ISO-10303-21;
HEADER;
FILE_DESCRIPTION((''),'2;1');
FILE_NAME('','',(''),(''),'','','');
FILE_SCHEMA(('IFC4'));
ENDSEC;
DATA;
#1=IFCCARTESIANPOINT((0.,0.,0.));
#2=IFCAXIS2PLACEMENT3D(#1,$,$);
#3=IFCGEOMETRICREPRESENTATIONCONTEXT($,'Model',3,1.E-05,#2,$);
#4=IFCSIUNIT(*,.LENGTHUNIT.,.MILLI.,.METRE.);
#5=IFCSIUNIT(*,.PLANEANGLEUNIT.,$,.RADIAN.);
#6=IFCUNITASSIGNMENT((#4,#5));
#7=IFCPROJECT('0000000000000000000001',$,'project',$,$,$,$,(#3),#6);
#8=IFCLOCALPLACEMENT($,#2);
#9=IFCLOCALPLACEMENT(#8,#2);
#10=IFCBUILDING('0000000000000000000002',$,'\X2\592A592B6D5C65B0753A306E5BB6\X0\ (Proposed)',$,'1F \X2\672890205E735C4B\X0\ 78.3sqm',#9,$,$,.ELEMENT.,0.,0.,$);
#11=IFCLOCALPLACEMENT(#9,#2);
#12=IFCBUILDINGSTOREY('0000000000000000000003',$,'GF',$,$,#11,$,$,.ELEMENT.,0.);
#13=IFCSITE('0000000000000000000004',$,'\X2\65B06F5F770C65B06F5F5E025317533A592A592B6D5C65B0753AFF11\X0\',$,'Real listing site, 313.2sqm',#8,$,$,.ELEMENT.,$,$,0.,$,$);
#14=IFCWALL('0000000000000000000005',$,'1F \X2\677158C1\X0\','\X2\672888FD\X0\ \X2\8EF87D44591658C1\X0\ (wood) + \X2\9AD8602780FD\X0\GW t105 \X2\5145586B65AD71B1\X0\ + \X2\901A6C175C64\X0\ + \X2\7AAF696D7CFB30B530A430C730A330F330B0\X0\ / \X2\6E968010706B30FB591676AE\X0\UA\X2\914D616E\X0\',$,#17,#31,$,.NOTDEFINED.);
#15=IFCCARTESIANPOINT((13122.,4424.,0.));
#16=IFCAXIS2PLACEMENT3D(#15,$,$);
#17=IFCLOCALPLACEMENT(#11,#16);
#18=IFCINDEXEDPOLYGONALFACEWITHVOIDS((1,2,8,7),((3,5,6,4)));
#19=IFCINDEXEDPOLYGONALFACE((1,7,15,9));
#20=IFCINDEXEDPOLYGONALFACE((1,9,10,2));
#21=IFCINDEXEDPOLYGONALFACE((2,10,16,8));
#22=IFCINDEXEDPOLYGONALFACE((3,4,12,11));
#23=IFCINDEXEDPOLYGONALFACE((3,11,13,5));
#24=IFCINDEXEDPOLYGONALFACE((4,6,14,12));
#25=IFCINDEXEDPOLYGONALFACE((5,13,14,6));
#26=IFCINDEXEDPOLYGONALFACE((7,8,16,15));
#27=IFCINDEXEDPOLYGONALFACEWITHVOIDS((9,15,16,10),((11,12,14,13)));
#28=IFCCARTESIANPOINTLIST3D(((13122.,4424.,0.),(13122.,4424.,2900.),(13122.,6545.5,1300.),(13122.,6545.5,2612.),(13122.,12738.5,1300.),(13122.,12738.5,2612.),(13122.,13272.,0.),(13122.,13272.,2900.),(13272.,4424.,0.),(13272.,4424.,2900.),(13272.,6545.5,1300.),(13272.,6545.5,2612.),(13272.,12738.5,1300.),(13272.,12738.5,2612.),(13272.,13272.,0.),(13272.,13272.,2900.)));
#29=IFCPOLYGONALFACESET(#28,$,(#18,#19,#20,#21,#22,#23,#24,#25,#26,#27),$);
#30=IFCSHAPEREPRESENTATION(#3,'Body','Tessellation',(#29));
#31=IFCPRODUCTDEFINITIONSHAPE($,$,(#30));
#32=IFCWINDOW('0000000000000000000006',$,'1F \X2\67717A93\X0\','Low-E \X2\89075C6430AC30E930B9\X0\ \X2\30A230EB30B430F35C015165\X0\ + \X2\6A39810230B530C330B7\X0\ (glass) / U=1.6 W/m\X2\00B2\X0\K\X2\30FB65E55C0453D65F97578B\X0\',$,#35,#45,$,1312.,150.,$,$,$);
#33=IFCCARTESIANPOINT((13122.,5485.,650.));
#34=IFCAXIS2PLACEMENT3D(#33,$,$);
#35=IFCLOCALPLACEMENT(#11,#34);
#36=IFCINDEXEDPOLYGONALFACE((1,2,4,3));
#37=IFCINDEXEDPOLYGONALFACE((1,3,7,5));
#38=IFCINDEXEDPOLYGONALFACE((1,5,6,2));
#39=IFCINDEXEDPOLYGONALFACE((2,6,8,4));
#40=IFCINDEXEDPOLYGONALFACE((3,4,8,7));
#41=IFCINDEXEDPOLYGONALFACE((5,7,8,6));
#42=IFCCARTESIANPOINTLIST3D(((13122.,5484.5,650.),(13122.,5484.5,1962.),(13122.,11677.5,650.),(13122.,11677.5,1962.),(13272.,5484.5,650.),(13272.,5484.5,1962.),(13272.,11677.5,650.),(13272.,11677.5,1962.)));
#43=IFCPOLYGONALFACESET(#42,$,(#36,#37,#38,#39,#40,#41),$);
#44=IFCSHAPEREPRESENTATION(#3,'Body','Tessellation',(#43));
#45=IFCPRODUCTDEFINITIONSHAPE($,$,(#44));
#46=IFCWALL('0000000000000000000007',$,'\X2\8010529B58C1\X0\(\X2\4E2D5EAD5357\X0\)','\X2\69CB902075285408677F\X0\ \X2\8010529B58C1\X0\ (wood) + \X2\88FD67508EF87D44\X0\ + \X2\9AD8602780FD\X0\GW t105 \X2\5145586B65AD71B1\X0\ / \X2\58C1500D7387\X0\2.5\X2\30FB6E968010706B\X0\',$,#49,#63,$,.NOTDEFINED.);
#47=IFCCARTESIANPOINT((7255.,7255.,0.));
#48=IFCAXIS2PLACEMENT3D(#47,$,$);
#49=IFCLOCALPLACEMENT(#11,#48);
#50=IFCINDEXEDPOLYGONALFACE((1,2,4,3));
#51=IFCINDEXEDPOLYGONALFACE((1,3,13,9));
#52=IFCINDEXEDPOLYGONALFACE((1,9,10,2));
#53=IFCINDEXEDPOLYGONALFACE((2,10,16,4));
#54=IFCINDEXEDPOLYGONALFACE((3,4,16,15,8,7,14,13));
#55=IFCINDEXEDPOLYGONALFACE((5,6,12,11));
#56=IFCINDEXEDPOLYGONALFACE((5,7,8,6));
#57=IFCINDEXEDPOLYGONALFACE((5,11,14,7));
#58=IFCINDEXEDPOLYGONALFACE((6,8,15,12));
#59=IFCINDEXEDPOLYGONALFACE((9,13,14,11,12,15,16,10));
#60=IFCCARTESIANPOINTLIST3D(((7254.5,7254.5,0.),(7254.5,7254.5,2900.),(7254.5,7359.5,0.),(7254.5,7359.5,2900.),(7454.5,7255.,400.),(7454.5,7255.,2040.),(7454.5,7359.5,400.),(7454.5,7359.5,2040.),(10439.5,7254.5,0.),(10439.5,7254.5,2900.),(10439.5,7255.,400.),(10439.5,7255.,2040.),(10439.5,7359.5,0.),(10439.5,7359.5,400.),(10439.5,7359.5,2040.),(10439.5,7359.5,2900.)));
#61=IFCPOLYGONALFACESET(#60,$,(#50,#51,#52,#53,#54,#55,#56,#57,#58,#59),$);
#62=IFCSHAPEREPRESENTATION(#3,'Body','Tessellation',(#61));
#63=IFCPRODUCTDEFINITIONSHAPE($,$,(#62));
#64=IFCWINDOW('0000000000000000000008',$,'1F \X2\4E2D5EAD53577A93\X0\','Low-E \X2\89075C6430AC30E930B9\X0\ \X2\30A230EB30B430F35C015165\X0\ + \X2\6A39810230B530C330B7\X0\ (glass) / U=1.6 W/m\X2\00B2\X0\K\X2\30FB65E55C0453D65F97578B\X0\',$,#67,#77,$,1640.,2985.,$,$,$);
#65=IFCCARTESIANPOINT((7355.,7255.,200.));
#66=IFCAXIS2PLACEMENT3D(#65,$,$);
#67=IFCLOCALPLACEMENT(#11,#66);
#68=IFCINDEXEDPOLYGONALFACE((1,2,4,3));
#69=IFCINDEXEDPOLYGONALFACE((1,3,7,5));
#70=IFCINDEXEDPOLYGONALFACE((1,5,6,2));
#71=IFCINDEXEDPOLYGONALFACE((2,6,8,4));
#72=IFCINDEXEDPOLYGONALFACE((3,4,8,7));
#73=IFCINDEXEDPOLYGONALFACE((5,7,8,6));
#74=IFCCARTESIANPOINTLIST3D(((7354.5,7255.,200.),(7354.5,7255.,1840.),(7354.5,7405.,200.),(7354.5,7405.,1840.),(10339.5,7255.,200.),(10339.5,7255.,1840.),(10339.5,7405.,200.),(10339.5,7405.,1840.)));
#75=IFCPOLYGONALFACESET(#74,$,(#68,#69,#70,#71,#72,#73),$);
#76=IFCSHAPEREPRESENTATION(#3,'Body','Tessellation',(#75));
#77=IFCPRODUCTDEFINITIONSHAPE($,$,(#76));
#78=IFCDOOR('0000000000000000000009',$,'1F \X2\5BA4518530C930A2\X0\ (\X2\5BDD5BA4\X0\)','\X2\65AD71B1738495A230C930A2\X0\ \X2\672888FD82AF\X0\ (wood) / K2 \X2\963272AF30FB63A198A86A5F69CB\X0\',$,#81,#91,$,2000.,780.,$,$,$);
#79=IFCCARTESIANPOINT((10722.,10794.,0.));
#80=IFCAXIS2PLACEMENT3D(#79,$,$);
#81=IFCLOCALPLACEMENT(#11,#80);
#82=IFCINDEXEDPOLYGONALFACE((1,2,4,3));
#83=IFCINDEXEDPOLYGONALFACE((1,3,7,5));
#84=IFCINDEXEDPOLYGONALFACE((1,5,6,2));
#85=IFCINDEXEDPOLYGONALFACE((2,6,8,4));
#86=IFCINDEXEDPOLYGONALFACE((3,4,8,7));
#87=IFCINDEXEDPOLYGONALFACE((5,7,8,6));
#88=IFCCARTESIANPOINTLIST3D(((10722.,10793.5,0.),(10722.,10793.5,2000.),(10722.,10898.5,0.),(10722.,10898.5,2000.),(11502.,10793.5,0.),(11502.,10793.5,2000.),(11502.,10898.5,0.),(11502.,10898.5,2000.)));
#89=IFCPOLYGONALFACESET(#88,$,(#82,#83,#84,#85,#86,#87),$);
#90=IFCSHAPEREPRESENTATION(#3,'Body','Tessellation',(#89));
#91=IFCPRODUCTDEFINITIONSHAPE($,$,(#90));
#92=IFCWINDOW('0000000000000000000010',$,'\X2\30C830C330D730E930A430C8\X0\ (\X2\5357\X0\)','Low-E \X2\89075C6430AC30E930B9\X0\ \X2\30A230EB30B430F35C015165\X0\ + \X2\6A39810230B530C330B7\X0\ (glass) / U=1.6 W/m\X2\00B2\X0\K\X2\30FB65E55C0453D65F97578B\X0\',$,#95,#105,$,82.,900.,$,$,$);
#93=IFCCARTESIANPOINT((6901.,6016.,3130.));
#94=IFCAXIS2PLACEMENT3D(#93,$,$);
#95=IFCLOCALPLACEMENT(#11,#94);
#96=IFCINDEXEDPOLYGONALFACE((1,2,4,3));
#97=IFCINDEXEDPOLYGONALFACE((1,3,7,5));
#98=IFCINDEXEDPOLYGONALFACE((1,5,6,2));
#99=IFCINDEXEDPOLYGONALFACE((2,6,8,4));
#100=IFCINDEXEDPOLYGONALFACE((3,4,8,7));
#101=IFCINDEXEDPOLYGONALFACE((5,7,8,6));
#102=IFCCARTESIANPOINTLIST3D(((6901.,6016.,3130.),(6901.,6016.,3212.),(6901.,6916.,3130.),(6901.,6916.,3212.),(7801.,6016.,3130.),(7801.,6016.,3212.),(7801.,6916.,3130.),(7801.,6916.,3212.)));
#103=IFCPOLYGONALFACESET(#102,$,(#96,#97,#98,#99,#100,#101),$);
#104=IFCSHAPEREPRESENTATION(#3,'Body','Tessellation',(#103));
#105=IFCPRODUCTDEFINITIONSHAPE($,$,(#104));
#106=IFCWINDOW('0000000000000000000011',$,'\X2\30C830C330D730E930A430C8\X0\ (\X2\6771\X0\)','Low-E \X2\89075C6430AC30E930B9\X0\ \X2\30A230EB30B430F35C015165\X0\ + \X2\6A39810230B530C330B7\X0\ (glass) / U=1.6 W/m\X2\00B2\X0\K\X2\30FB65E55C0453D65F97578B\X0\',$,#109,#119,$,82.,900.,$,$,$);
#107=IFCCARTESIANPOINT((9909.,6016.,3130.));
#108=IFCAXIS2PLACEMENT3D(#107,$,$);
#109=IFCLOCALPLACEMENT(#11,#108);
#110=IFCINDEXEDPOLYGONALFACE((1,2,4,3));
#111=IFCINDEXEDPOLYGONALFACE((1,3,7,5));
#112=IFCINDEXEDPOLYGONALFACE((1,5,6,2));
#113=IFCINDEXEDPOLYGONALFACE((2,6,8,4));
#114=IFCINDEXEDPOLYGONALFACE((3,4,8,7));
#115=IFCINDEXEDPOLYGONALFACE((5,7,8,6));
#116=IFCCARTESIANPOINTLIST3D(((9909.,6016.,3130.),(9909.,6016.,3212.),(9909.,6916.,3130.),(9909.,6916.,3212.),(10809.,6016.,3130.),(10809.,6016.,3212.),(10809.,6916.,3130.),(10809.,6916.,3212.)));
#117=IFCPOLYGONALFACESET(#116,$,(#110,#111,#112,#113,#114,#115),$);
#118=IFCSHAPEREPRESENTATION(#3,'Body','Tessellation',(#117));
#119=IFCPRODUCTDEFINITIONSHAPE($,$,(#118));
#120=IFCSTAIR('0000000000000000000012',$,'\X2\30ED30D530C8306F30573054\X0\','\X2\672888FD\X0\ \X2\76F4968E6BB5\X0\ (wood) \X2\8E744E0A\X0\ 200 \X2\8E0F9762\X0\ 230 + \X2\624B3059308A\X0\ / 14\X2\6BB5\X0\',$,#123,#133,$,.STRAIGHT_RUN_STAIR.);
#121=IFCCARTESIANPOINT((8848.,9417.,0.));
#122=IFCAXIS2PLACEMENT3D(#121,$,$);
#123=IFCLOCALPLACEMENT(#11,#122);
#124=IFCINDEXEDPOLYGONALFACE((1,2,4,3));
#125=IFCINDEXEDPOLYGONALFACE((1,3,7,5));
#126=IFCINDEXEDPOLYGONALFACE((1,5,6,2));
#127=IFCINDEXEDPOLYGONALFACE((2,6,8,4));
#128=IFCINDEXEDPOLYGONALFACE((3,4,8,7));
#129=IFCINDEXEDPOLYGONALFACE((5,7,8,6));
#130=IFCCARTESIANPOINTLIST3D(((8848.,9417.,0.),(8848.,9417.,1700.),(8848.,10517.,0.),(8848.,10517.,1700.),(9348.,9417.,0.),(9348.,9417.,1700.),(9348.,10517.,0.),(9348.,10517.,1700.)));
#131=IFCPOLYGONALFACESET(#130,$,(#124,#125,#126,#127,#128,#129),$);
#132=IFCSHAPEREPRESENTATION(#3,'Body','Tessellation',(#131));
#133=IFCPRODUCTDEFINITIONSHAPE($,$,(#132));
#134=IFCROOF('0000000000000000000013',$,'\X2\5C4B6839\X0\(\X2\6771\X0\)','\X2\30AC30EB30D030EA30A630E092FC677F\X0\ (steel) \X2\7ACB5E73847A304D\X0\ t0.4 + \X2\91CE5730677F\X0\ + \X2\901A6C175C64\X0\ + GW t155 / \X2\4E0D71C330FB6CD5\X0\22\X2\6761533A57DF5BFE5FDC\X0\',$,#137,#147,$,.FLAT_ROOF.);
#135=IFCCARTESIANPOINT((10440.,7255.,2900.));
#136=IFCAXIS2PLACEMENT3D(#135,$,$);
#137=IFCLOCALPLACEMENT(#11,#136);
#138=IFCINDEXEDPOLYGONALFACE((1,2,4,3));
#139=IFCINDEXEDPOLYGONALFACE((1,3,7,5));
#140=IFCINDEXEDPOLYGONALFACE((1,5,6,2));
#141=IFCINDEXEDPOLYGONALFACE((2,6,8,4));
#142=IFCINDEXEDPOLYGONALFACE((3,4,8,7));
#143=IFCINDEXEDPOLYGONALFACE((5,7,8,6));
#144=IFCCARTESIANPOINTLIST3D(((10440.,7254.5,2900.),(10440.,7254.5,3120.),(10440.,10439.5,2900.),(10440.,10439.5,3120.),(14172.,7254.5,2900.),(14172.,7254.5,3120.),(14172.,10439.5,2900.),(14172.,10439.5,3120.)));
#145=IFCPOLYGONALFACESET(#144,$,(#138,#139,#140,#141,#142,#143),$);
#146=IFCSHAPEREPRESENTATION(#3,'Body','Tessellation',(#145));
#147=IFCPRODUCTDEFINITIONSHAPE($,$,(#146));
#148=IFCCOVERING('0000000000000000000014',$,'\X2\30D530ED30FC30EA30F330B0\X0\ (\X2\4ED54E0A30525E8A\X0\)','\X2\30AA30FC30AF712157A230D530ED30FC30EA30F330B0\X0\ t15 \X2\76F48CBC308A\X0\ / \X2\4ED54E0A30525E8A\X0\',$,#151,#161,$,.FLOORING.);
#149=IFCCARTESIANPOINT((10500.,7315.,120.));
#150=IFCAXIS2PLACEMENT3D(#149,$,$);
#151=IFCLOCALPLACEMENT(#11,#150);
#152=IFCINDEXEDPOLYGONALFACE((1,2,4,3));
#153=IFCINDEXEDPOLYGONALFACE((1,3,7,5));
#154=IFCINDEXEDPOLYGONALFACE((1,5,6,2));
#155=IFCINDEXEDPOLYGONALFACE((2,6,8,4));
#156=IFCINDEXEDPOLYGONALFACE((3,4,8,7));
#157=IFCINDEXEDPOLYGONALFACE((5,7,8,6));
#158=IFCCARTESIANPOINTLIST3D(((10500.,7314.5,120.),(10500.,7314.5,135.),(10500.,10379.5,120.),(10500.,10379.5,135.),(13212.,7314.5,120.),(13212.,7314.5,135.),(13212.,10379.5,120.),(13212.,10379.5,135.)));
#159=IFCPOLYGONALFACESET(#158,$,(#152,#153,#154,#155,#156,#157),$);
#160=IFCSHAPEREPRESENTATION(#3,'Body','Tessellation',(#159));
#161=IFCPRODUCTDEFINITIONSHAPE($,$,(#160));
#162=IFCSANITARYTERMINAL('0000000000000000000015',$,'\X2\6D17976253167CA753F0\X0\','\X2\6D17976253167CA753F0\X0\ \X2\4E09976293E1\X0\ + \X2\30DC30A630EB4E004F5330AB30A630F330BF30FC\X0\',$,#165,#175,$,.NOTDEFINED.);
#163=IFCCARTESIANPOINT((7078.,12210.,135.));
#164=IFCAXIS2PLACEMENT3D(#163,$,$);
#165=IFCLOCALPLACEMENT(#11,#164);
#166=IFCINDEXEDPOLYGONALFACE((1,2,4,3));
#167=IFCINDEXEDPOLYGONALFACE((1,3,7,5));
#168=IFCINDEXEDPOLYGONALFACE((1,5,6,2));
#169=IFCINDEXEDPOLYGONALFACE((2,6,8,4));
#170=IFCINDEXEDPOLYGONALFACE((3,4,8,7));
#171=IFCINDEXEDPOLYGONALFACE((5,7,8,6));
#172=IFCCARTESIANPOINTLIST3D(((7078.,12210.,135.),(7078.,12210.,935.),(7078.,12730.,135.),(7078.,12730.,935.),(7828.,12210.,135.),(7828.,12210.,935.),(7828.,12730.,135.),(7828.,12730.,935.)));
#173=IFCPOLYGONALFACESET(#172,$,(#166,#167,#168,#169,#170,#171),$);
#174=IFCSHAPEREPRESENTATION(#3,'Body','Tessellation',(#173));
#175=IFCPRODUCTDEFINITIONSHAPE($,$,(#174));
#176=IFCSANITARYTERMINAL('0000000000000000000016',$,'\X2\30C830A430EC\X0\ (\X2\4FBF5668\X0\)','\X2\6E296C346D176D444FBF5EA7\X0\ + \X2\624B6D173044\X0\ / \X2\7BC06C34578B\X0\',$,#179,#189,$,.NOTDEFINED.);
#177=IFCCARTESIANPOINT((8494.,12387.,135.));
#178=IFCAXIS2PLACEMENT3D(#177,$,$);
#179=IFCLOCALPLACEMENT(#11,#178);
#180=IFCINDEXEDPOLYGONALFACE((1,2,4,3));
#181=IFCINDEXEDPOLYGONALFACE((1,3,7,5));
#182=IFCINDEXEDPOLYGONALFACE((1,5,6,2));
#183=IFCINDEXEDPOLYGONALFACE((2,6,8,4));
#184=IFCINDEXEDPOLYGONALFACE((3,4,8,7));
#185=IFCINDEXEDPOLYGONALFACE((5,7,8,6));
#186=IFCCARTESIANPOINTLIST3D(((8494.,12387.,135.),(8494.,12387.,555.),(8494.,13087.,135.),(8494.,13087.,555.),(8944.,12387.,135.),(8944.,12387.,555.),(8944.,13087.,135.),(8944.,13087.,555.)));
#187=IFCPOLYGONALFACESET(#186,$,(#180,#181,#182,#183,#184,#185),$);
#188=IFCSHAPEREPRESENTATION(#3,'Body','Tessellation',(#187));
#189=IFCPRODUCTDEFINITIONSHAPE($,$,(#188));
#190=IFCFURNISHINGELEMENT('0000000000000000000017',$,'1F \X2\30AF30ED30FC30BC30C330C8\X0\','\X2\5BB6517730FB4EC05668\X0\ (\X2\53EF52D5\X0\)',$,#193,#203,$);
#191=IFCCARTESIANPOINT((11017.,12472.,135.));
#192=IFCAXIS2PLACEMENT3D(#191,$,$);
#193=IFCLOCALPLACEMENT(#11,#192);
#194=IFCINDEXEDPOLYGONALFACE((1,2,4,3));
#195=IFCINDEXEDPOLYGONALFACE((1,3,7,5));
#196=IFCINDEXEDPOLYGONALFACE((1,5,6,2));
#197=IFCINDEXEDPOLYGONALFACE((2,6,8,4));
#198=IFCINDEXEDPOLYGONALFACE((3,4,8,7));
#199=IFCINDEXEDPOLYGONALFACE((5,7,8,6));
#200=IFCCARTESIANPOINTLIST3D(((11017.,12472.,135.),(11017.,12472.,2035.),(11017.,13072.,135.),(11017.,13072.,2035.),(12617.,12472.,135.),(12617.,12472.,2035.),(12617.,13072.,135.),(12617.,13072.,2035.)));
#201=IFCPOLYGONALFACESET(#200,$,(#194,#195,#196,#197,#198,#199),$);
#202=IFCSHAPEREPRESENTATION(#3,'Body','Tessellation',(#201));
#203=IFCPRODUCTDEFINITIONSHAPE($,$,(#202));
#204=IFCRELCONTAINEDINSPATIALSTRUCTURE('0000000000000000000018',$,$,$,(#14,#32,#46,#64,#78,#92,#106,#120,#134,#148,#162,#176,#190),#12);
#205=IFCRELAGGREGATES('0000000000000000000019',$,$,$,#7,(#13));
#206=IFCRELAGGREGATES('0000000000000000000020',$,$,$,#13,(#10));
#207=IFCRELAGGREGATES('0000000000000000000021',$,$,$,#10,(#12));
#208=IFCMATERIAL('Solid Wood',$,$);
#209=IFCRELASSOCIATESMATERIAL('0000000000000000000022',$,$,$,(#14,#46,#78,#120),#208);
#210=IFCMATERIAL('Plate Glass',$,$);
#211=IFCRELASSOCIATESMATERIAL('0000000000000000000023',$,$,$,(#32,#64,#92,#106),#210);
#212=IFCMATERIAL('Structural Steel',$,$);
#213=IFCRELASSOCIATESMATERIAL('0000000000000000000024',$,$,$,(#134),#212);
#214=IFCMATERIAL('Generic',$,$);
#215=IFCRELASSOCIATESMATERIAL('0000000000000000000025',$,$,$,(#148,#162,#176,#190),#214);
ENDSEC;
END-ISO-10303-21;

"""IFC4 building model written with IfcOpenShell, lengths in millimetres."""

from ifc_helpers import new_model, si_unit, frame, frame_2d, origin, place, context, project, spatial, rectangle, extrude, material, element, fill, save


model = new_model("IFC4")

# Units and contexts
model_context = context("Model", 3, precision=1e-05, world=origin())
ifc_project = project(units=[si_unit("LENGTHUNIT", "METRE", prefix="MILLI"), si_unit("PLANEANGLEUNIT", "RADIAN")], contexts=[model_context])

# Site, building, storey
site_placement = place(None, origin())
site = spatial("IfcSite", under=ifc_project, at=site_placement, Name="新潟県新潟市北区太夫浜新町１", ObjectType="Real listing site, 313.2sqm", CompositionType="ELEMENT", RefElevation=0.0)
building_placement = place(site_placement, origin())
building = spatial("IfcBuilding", under=site, at=building_placement, Name="太夫浜新町の家 (Proposed)", ObjectType="1F 木造平屋 78.3sqm", CompositionType="ELEMENT", ElevationOfRefHeight=0.0, ElevationOfTerrain=0.0)
storey_placement = place(building_placement, origin())
storey = spatial("IfcBuildingStorey", under=building, at=storey_placement, Name="GF", CompositionType="ELEMENT", Elevation=0.0)

# Shared definitions
ifc_material_1 = material(Name="Solid Wood")

# Walls, openings, windows
wall_1_placement = place(storey_placement, frame((13122.0, 4424.0, 0.0)))
wall_1 = element("IfcWall", 1, at=wall_1_placement, inside=storey, material=ifc_material_1, Name="1F 東壁", Description="木製 軸組外壁 (wood) + 高性能GW t105 充填断熱 + 通気層 + 窯業系サイディング / 準耐火・外皮UA配慮", PredefinedType="NOTDEFINED", context=model_context, shape_type="SweptSolid", body=[
    extrude(rectangle(XDim=150.0, YDim=8848.0, at=frame_2d((75.0, 4424.0))), frame((13122.0, 4424.0, 0.0)), (0.0, 0.0, 1.0), 2900.0),
])
opening_1_placement = place(storey_placement, frame((13122.0, 5485.0, 650.0)))
opening_1 = element("IfcOpeningElement", 2, at=opening_1_placement, cuts=wall_1, PredefinedType="NOTDEFINED", context=model_context, shape_type="SweptSolid", body=[
    extrude(rectangle(XDim=150.0, YDim=6193.0, at=frame_2d((75.0, 3096.0))), frame((13122.0, 5485.0, 650.0)), (0.0, 0.0, 1.0), 1312.0),
])
ifc_material_2 = material(Name="Plate Glass")
window_1_placement = place(storey_placement, frame((13122.0, 5485.0, 650.0)))
window_1 = element("IfcWindow", 3, at=window_1_placement, inside=storey, material=ifc_material_2, Name="1F 東窓", Description="Low-E 複層ガラス アルゴン封入 + 樹脂サッシ (glass) / U=1.6 W/m²K・日射取得型", OverallHeight=1312.0, OverallWidth=150.0, context=model_context, shape_type="SweptSolid", body=[
    extrude(rectangle(XDim=150.0, YDim=6193.0, at=frame_2d((75.0, 3096.0))), frame((13122.0, 5485.0, 650.0)), (0.0, 0.0, 1.0), 1312.0),
])
fill(opening_1, window_1)
wall_2_placement = place(storey_placement, frame((7255.0, 7255.0, 0.0)))
wall_2 = element("IfcWall", 4, at=wall_2_placement, inside=storey, material=ifc_material_1, Name="耐力壁(中庭南)", Description="構造用合板 耐力壁 (wood) + 製材軸組 + 高性能GW t105 充填断熱 / 壁倍率2.5・準耐火", PredefinedType="NOTDEFINED", context=model_context, shape_type="SweptSolid", body=[
    extrude(rectangle(XDim=3185.0, YDim=105.0, at=frame_2d((1592.0, 52.0))), frame((7255.0, 7255.0, 0.0)), (0.0, 0.0, 1.0), 2900.0),
])
opening_2_placement = place(storey_placement, frame((7355.0, 7255.0, 200.0)))
opening_2 = element("IfcOpeningElement", 5, at=opening_2_placement, cuts=wall_2, PredefinedType="NOTDEFINED", context=model_context, shape_type="SweptSolid", body=[
    extrude(rectangle(XDim=2985.0, YDim=150.0, at=frame_2d((1492.0, 75.0))), frame((7355.0, 7255.0, 200.0)), (0.0, 0.0, 1.0), 1640.0),
])
window_2_placement = place(storey_placement, frame((7355.0, 7255.0, 200.0)))
window_2 = element("IfcWindow", 6, at=window_2_placement, inside=storey, material=ifc_material_2, Name="1F 中庭南窓", Description="Low-E 複層ガラス アルゴン封入 + 樹脂サッシ (glass) / U=1.6 W/m²K・日射取得型", OverallHeight=1640.0, OverallWidth=2985.0, context=model_context, shape_type="SweptSolid", body=[
    extrude(rectangle(XDim=2985.0, YDim=150.0, at=frame_2d((1492.0, 75.0))), frame((7355.0, 7255.0, 200.0)), (0.0, 0.0, 1.0), 1640.0),
])
fill(opening_2, window_2)

# Door
door_placement = place(storey_placement, frame((10722.0, 10794.0, 0.0)))
element("IfcDoor", 7, at=door_placement, inside=storey, material=ifc_material_1, Name="1F 室内ドア (寝室)", Description="断熱玄関ドア 木製芯 (wood) / K2 防犯・採風機構", OverallHeight=2000.0, OverallWidth=780.0, context=model_context, shape_type="SweptSolid", body=[
    extrude(rectangle(XDim=780.0, YDim=105.0, at=frame_2d((390.0, 52.0))), frame((10722.0, 10794.0, 0.0)), (0.0, 0.0, 1.0), 2000.0),
])

# Windows
window_3_placement = place(storey_placement, frame((6901.0, 6016.0, 3130.0)))
element("IfcWindow", 8, at=window_3_placement, inside=storey, material=ifc_material_2, Name="トップライト (南)", Description="Low-E 複層ガラス アルゴン封入 + 樹脂サッシ (glass) / U=1.6 W/m²K・日射取得型", OverallHeight=82.0, OverallWidth=900.0, context=model_context, shape_type="SweptSolid", body=[
    extrude(rectangle(XDim=900.0, YDim=900.0, at=frame_2d((450.0, 450.0))), frame((6901.0, 6016.0, 3130.0)), (0.0, 0.0, 1.0), 82.0),
])
window_4_placement = place(storey_placement, frame((9909.0, 6016.0, 3130.0)))
element("IfcWindow", 9, at=window_4_placement, inside=storey, material=ifc_material_2, Name="トップライト (東)", Description="Low-E 複層ガラス アルゴン封入 + 樹脂サッシ (glass) / U=1.6 W/m²K・日射取得型", OverallHeight=82.0, OverallWidth=900.0, context=model_context, shape_type="SweptSolid", body=[
    extrude(rectangle(XDim=900.0, YDim=900.0, at=frame_2d((450.0, 450.0))), frame((9909.0, 6016.0, 3130.0)), (0.0, 0.0, 1.0), 82.0),
])

# Stair
stair_placement = place(storey_placement, frame((8848.0, 9417.0, 0.0)))
element("IfcStair", 10, at=stair_placement, inside=storey, material=ifc_material_1, Name="ロフトはしご", Description="木製 直階段 (wood) 蹴上 200 踏面 230 + 手すり / 14段", PredefinedType="STRAIGHT_RUN_STAIR", context=model_context, shape_type="SweptSolid", body=[
    extrude(rectangle(XDim=500.0, YDim=1100.0, at=frame_2d((250.0, 550.0))), frame((8848.0, 9417.0, 0.0)), (0.0, 0.0, 1.0), 1700.0),
])

# Roof
ifc_material_3 = material(Name="Structural Steel")
roof_placement = place(storey_placement, frame((10440.0, 7255.0, 2900.0)))
element("IfcRoof", 11, at=roof_placement, inside=storey, material=ifc_material_3, Name="屋根(東)", Description="ガルバリウム鋼板 (steel) 立平葺き t0.4 + 野地板 + 通気層 + GW t155 / 不燃・法22条区域対応", PredefinedType="FLAT_ROOF", context=model_context, shape_type="SweptSolid", body=[
    extrude(rectangle(XDim=3732.0, YDim=3185.0, at=frame_2d((1866.0, 1592.0))), frame((10440.0, 7255.0, 2900.0)), (0.0, 0.0, 1.0), 220.0),
])

# Covering
ifc_material_4 = material(Name="Generic")
covering_placement = place(storey_placement, frame((10500.0, 7315.0, 120.0)))
element("IfcCovering", 12, at=covering_placement, inside=storey, material=ifc_material_4, Name="フローリング (仕上げ床)", Description="オーク無垢フローリング t15 直貼り / 仕上げ床", PredefinedType="FLOORING", context=model_context, shape_type="SweptSolid", body=[
    extrude(rectangle(XDim=2712.0, YDim=3065.0, at=frame_2d((1356.0, 1532.0))), frame((10500.0, 7315.0, 120.0)), (0.0, 0.0, 1.0), 15.0),
])

# Sanitary terminals
sanitary_terminal_1_placement = place(storey_placement, frame((7078.0, 12210.0, 135.0)))
element("IfcSanitaryTerminal", 13, at=sanitary_terminal_1_placement, inside=storey, material=ifc_material_4, Name="洗面化粧台", Description="洗面化粧台 三面鏡 + ボウル一体カウンター", PredefinedType="NOTDEFINED", context=model_context, shape_type="SweptSolid", body=[
    extrude(rectangle(XDim=750.0, YDim=520.0, at=frame_2d((375.0, 260.0))), frame((7078.0, 12210.0, 135.0)), (0.0, 0.0, 1.0), 800.0),
])
sanitary_terminal_2_placement = place(storey_placement, frame((8494.0, 12387.0, 135.0)))
element("IfcSanitaryTerminal", 14, at=sanitary_terminal_2_placement, inside=storey, material=ifc_material_4, Name="トイレ (便器)", Description="温水洗浄便座 + 手洗い / 節水型", PredefinedType="NOTDEFINED", context=model_context, shape_type="SweptSolid", body=[
    extrude(rectangle(XDim=450.0, YDim=700.0, at=frame_2d((225.0, 350.0))), frame((8494.0, 12387.0, 135.0)), (0.0, 0.0, 1.0), 420.0),
])

# Furnishing element
furnishing_1_placement = place(storey_placement, frame((11017.0, 12472.0, 135.0)))
element("IfcFurnishingElement", 15, at=furnishing_1_placement, inside=storey, material=ifc_material_4, Name="1F クローゼット", Description="家具・什器 (可動)", context=model_context, shape_type="SweptSolid", body=[
    extrude(rectangle(XDim=1600.0, YDim=600.0, at=frame_2d((800.0, 300.0))), frame((11017.0, 12472.0, 135.0)), (0.0, 0.0, 1.0), 1900.0),
])

save(model, "model.ifc")
